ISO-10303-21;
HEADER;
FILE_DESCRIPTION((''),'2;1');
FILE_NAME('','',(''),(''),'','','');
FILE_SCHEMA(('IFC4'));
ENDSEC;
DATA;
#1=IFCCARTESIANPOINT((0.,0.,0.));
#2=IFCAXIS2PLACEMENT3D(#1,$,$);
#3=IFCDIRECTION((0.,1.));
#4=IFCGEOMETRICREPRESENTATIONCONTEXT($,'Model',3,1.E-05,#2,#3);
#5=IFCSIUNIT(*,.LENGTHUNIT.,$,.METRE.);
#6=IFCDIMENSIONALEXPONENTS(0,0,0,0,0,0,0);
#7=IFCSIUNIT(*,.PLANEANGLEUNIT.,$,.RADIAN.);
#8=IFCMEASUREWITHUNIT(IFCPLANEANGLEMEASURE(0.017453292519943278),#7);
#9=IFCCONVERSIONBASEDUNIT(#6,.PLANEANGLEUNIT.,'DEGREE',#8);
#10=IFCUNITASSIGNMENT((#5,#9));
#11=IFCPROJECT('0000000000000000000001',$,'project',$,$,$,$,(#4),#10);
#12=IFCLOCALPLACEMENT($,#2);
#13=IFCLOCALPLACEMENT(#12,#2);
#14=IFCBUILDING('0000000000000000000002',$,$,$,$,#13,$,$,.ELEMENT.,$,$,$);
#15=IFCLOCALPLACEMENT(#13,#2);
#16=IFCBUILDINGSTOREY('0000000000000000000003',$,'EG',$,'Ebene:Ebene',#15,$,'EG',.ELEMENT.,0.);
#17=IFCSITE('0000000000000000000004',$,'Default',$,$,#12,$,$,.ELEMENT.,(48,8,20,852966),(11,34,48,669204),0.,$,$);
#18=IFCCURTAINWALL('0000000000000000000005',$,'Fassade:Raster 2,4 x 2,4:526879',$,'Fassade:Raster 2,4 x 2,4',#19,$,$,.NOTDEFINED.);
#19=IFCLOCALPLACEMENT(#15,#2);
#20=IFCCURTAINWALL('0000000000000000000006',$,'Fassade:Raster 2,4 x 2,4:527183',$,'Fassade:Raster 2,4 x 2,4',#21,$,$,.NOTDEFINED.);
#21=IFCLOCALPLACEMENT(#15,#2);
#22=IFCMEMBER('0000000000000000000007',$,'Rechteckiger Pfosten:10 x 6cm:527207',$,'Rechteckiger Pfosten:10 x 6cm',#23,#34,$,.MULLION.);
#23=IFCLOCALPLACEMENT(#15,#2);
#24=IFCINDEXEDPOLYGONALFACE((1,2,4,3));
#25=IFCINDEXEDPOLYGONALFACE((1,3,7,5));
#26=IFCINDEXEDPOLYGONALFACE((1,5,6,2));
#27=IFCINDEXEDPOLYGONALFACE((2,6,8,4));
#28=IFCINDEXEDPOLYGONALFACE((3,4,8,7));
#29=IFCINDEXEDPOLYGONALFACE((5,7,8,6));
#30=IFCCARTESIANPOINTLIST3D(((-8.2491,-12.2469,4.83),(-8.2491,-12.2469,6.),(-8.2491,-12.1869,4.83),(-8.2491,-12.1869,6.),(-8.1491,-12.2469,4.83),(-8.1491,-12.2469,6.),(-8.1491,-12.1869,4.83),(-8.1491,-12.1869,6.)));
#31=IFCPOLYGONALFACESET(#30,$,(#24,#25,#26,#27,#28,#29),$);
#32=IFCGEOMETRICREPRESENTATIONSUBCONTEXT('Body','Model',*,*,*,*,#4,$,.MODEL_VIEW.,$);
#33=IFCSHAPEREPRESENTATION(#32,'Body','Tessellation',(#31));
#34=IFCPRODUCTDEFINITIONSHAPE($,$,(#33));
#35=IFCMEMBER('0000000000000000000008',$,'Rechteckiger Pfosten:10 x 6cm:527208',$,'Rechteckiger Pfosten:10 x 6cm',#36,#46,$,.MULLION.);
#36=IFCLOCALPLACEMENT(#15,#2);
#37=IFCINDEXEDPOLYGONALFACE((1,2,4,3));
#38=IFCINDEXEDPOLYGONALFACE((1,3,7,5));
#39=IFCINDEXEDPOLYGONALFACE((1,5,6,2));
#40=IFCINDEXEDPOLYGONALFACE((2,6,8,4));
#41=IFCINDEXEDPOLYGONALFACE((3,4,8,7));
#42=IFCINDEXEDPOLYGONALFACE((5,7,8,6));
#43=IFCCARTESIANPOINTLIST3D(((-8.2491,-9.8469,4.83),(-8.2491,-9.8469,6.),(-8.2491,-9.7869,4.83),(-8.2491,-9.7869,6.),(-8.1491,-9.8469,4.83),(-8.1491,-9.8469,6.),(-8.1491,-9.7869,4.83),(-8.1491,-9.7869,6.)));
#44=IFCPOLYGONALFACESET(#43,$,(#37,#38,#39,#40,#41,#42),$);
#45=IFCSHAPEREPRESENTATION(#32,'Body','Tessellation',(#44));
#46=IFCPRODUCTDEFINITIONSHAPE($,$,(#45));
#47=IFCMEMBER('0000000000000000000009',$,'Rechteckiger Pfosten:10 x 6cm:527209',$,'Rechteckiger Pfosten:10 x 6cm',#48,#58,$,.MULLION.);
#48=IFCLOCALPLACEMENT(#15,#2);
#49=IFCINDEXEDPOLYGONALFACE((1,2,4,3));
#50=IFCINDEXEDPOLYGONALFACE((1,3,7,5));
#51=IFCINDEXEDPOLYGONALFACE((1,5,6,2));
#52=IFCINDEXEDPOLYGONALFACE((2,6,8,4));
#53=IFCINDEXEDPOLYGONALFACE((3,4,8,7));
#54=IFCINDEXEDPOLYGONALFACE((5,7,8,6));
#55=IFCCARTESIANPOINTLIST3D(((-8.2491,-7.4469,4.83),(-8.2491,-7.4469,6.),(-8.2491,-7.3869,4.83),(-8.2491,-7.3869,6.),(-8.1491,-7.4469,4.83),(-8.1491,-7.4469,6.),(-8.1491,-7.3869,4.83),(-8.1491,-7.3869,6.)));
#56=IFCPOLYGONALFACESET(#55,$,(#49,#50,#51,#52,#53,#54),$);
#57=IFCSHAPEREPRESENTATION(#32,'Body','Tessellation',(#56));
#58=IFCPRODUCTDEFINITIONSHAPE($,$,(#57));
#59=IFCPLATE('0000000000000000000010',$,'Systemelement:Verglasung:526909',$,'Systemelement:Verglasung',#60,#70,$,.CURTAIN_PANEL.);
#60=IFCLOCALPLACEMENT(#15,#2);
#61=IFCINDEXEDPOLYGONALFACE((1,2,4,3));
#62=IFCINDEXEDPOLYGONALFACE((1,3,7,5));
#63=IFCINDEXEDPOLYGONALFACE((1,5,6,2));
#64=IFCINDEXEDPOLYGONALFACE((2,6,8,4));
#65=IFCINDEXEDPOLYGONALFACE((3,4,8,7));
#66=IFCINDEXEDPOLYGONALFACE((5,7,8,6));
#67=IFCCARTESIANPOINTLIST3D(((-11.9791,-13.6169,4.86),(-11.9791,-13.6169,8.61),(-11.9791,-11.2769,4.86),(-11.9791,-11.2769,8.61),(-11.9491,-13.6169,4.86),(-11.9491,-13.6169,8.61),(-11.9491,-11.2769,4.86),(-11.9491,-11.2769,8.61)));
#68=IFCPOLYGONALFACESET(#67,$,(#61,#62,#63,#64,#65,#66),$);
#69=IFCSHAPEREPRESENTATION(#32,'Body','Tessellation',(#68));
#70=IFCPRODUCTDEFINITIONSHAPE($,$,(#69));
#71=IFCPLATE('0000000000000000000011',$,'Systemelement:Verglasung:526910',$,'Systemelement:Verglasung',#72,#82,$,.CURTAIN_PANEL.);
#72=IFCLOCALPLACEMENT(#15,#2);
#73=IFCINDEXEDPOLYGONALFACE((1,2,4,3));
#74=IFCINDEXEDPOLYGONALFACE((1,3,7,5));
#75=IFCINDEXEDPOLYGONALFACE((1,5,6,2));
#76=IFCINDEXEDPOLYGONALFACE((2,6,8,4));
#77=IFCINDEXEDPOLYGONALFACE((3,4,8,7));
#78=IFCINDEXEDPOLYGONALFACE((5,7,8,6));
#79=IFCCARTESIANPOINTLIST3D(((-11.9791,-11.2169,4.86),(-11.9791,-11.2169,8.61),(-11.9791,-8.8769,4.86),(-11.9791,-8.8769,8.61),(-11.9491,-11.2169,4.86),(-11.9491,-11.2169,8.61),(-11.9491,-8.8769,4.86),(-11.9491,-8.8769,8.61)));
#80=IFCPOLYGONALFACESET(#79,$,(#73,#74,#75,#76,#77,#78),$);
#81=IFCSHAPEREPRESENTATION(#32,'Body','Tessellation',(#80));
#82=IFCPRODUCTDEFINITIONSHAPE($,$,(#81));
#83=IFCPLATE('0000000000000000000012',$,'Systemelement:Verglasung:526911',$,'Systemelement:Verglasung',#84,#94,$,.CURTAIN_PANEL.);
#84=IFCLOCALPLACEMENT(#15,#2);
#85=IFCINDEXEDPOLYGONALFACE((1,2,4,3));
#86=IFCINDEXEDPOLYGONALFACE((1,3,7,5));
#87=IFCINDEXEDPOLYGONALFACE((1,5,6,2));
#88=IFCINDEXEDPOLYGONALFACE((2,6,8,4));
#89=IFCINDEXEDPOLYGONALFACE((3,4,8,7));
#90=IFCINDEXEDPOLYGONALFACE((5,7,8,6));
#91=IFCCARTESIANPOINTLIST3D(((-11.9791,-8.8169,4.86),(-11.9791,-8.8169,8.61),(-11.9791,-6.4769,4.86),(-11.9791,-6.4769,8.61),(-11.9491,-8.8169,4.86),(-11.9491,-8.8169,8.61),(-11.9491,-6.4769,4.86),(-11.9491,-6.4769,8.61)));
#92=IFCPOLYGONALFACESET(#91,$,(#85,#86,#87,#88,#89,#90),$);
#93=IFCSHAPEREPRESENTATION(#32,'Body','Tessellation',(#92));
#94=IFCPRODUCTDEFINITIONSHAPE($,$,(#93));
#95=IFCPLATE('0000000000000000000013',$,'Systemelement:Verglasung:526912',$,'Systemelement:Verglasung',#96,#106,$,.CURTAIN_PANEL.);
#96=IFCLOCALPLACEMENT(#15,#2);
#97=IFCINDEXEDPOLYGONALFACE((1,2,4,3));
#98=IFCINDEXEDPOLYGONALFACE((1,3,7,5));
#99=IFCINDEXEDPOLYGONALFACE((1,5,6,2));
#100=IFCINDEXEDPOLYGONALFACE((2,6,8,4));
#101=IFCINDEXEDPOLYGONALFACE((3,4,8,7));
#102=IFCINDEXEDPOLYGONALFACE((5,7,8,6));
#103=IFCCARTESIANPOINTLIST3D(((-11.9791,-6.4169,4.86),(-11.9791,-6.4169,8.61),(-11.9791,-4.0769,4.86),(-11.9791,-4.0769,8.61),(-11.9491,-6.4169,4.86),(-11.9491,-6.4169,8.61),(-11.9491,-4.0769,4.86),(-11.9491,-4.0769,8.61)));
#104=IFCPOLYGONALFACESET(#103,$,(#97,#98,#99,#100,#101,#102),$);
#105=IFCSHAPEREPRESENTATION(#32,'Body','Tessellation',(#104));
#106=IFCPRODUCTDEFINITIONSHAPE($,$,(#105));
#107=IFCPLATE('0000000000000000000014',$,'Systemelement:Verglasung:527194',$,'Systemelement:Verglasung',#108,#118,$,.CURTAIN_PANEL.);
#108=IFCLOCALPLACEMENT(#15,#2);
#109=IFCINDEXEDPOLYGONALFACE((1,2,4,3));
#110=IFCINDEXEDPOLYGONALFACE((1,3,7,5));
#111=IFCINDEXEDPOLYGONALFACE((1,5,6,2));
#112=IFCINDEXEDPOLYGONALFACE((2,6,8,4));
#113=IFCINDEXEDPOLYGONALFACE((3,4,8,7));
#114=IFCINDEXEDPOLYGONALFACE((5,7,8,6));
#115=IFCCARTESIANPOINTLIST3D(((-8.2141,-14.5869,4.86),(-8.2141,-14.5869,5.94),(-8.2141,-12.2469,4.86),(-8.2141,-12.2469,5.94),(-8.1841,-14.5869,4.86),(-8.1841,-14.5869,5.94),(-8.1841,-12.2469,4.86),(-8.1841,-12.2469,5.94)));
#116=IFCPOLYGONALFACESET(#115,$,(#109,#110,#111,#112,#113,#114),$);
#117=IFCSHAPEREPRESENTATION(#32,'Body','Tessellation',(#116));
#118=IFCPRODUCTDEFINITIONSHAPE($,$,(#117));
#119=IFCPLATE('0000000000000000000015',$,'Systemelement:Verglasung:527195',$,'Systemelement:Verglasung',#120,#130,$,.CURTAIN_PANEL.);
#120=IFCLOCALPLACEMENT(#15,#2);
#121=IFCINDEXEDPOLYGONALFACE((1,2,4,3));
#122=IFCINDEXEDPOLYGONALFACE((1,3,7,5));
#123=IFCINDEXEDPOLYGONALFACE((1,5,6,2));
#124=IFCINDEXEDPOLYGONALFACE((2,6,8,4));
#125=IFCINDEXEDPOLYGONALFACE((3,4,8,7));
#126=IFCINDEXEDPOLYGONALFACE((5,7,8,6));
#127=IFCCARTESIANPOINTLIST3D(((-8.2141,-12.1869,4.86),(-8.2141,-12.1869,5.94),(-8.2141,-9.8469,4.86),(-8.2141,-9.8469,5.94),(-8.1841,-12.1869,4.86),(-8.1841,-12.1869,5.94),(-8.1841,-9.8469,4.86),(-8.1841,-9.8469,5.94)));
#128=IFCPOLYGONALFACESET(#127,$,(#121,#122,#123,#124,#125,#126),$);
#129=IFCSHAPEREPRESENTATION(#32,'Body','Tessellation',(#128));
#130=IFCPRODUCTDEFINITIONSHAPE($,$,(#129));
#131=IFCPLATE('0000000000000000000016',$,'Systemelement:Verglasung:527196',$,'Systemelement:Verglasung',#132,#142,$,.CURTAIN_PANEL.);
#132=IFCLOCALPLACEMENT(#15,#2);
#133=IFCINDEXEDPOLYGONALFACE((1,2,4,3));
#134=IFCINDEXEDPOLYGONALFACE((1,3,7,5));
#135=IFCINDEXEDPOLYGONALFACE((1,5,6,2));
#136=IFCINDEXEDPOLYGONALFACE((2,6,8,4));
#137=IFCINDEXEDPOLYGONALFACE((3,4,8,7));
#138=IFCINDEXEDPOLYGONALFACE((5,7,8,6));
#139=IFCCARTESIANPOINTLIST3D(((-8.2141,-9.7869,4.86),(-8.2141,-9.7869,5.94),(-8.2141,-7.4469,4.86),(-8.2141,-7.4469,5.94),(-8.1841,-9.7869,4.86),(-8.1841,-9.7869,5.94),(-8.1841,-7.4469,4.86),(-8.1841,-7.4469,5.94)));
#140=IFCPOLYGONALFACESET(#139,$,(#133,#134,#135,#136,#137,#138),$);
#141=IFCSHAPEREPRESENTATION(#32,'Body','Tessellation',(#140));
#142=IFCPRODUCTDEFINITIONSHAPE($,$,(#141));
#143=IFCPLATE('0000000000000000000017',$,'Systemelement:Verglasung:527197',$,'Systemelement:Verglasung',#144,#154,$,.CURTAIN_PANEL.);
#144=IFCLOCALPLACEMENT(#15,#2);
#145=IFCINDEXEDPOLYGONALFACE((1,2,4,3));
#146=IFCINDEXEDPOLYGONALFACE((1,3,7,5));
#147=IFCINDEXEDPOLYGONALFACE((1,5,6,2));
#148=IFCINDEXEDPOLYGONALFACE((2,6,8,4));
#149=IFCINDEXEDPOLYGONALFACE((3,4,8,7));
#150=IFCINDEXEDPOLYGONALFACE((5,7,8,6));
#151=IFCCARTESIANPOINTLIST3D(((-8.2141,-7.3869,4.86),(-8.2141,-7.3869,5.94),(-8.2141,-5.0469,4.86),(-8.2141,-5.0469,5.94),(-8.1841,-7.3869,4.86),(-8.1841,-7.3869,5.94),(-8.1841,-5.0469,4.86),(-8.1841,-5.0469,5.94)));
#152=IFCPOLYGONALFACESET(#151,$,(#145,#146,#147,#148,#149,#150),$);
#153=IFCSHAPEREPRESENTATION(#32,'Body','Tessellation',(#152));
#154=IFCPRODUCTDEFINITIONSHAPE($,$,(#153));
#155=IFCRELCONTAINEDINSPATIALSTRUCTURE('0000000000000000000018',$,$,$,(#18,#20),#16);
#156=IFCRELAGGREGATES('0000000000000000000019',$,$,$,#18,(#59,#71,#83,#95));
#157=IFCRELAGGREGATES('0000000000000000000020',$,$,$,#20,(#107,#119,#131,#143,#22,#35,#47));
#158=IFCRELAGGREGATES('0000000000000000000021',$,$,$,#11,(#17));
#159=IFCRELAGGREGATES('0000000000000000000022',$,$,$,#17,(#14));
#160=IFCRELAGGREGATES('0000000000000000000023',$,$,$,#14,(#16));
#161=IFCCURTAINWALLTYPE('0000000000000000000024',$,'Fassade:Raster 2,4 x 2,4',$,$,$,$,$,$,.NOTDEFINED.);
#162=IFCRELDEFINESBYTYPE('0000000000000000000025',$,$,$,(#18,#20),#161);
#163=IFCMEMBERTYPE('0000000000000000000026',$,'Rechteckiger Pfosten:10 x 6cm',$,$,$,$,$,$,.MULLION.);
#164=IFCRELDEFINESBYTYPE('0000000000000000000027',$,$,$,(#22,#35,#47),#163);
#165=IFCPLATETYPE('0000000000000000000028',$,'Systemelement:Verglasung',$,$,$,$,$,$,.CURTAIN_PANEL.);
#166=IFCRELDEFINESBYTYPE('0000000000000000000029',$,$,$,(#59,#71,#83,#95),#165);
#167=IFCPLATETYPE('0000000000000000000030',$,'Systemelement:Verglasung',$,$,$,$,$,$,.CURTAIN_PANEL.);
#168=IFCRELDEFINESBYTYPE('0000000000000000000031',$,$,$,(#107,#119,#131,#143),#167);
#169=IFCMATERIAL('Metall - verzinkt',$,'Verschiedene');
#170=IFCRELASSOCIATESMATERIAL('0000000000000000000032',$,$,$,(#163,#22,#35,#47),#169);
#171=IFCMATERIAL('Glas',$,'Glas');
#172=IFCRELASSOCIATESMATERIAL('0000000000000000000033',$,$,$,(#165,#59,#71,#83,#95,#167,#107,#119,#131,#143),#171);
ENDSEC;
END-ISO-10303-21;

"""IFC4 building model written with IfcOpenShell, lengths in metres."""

from ifc_helpers import new_model, entity, si_unit, converted_unit, direction, frame, origin, place, context, subcontext, project, spatial, indexed_curve, outline, extrude, source, transform, mapped, material, type_object, type_shapes, element, aggregate, save


model = new_model("IFC4")

# Units and contexts
model_context = context("Model", 3, precision=1e-05, world=origin(), true_north=direction((0.0, 1.0)))
body_context = subcontext(model_context, "Body", "Model", "MODEL_VIEW")
ifc_project = project(units=[si_unit("LENGTHUNIT", "METRE"), converted_unit("PLANEANGLEUNIT", "DEGREE", entity("IfcPlaneAngleMeasure", 0.017453292519943278), si_unit("PLANEANGLEUNIT", "RADIAN"), dimensions=[0, 0, 0, 0, 0, 0, 0])], contexts=[model_context])

# Site, building, storey
site_placement = place(None, origin())
site = spatial("IfcSite", under=ifc_project, at=site_placement, Name="Default", CompositionType="ELEMENT", RefLatitude=(48, 8, 20, 852966), RefLongitude=(11, 34, 48, 669204), RefElevation=0.0)
building_placement = place(site_placement, origin())
building = spatial("IfcBuilding", under=site, at=building_placement, CompositionType="ELEMENT")
storey_placement = place(building_placement, origin())
storey = spatial("IfcBuildingStorey", under=building, at=storey_placement, Name="EG", ObjectType="Ebene:Ebene", LongName="EG", CompositionType="ELEMENT", Elevation=0.0)

# Curtain walls
curtain_wall_type = type_object("IfcCurtainWallType", Name="Fassade:Raster 2,4 x 2,4", PredefinedType="NOTDEFINED")
curtain_wall_1_placement = place(storey_placement, origin())
curtain_wall_1 = element("IfcCurtainWall", 1, at=curtain_wall_1_placement, inside=storey, type_object=curtain_wall_type, Name="Fassade:Raster 2,4 x 2,4:526879", ObjectType="Fassade:Raster 2,4 x 2,4", PredefinedType="NOTDEFINED")
ifc_material_1 = material(Name="Metall - verzinkt", Category="Verschiedene")
curtain_wall_2_placement = place(storey_placement, origin())
curtain_wall_2 = element("IfcCurtainWall", 2, at=curtain_wall_2_placement, inside=storey, type_object=curtain_wall_type, Name="Fassade:Raster 2,4 x 2,4:527183", ObjectType="Fassade:Raster 2,4 x 2,4", PredefinedType="NOTDEFINED")

# Members
member_type_1 = type_object("IfcMemberType", Name="Rechteckiger Pfosten:10 x 6cm", PredefinedType="MULLION", material=ifc_material_1)
shared_shape_1 = source(origin(), body_context, "Body", "SweptSolid", [
    extrude(outline(indexed_curve([(-0.03, -0.05), (0.03, -0.05), (0.03, 0.05), (-0.03, 0.05), (-0.03, -0.05)], self_intersect=False)), frame((0.0, 0.0, -1.17), z_axis=(0.0, 0.0, 1.0), x_axis=(-1.0, 0.0, 0.0)), (0.0, 0.0, 1.0), 1.17),
])
type_shapes(member_type_1, [shared_shape_1])
member_1_placement = place(curtain_wall_2_placement, frame((-8.1991, -12.2169, 4.83), z_axis=(0.0, 0.0, -1.0), x_axis=(0.0, 1.0, 0.0)))
member_1 = element("IfcMember", 3, at=member_1_placement, type_object=member_type_1, material=ifc_material_1, Name="Rechteckiger Pfosten:10 x 6cm:527207", ObjectType="Rechteckiger Pfosten:10 x 6cm", PredefinedType="MULLION", context=body_context, shape_type="MappedRepresentation", body=[
    mapped(shared_shape_1, transform((0.0, 0.0, 0.0), scale=1.0)),
])
member_2_placement = place(curtain_wall_2_placement, frame((-8.1991, -9.8169, 4.83), z_axis=(0.0, 0.0, -1.0), x_axis=(0.0, 1.0, 0.0)))
member_2 = element("IfcMember", 4, at=member_2_placement, type_object=member_type_1, material=ifc_material_1, Name="Rechteckiger Pfosten:10 x 6cm:527208", ObjectType="Rechteckiger Pfosten:10 x 6cm", PredefinedType="MULLION", context=body_context, shape_type="MappedRepresentation", body=[
    mapped(shared_shape_1, transform((0.0, 0.0, 0.0), scale=1.0)),
])
member_3_placement = place(curtain_wall_2_placement, frame((-8.1991, -7.4169, 4.83), z_axis=(0.0, 0.0, -1.0), x_axis=(0.0, 1.0, 0.0)))
member_3 = element("IfcMember", 5, at=member_3_placement, type_object=member_type_1, material=ifc_material_1, Name="Rechteckiger Pfosten:10 x 6cm:527209", ObjectType="Rechteckiger Pfosten:10 x 6cm", PredefinedType="MULLION", context=body_context, shape_type="MappedRepresentation", body=[
    mapped(shared_shape_1, transform((0.0, 0.0, 0.0), scale=1.0)),
])

# Plates
ifc_material_2 = material(Name="Glas", Category="Glas")
plate_type_1 = type_object("IfcPlateType", Name="Systemelement:Verglasung", PredefinedType="CURTAIN_PANEL", material=ifc_material_2)
shared_shape_2 = source(origin(), body_context, "Body", "SweptSolid", [
    extrude(outline(indexed_curve([(-0.015, -1.17), (0.015, -1.17), (0.015, 1.17), (-0.015, 1.17), (-0.015, -1.17)], self_intersect=False)), frame((0.0, 0.0, 0.0), z_axis=(0.0, 0.0, 1.0), x_axis=(0.0, 1.0, 0.0)), (0.0, 0.0, 1.0), 3.75),
])
type_shapes(plate_type_1, [shared_shape_2])
plate_1_placement = place(curtain_wall_1_placement, frame((-11.9641, -12.4469, 4.86), z_axis=(0.0, 0.0, 1.0), x_axis=(0.0, 1.0, 0.0)))
plate_1 = element("IfcPlate", 6, at=plate_1_placement, type_object=plate_type_1, material=ifc_material_2, Name="Systemelement:Verglasung:526909", ObjectType="Systemelement:Verglasung", PredefinedType="CURTAIN_PANEL", context=body_context, shape_type="MappedRepresentation", body=[
    mapped(shared_shape_2, transform((0.0, 0.0, 0.0), scale=1.0)),
])
plate_2_placement = place(curtain_wall_1_placement, frame((-11.9641, -10.0469, 4.86), z_axis=(0.0, 0.0, 1.0), x_axis=(0.0, 1.0, 0.0)))
plate_2 = element("IfcPlate", 7, at=plate_2_placement, type_object=plate_type_1, material=ifc_material_2, Name="Systemelement:Verglasung:526910", ObjectType="Systemelement:Verglasung", PredefinedType="CURTAIN_PANEL", context=body_context, shape_type="MappedRepresentation", body=[
    mapped(shared_shape_2, transform((0.0, 0.0, 0.0), scale=1.0)),
])
plate_3_placement = place(curtain_wall_1_placement, frame((-11.9641, -7.6469, 4.86), z_axis=(0.0, 0.0, 1.0), x_axis=(0.0, 1.0, 0.0)))
plate_3 = element("IfcPlate", 8, at=plate_3_placement, type_object=plate_type_1, material=ifc_material_2, Name="Systemelement:Verglasung:526911", ObjectType="Systemelement:Verglasung", PredefinedType="CURTAIN_PANEL", context=body_context, shape_type="MappedRepresentation", body=[
    mapped(shared_shape_2, transform((0.0, 0.0, 0.0), scale=1.0)),
])
plate_4_placement = place(curtain_wall_1_placement, frame((-11.9641, -5.2469, 4.86), z_axis=(0.0, 0.0, 1.0), x_axis=(0.0, 1.0, 0.0)))
plate_4 = element("IfcPlate", 9, at=plate_4_placement, type_object=plate_type_1, material=ifc_material_2, Name="Systemelement:Verglasung:526912", ObjectType="Systemelement:Verglasung", PredefinedType="CURTAIN_PANEL", context=body_context, shape_type="MappedRepresentation", body=[
    mapped(shared_shape_2, transform((0.0, 0.0, 0.0), scale=1.0)),
])
aggregate(curtain_wall_1, [plate_1, plate_2, plate_3, plate_4])
plate_type_2 = type_object("IfcPlateType", Name="Systemelement:Verglasung", PredefinedType="CURTAIN_PANEL", material=ifc_material_2)
shared_shape_3 = source(origin(), body_context, "Body", "SweptSolid", [
    extrude(outline(indexed_curve([(-0.015, -1.17), (0.015, -1.17), (0.015, 1.17), (-0.015, 1.17), (-0.015, -1.17)], self_intersect=False)), frame((0.0, 0.0, 0.0), z_axis=(0.0, 0.0, 1.0), x_axis=(0.0, 1.0, 0.0)), (0.0, 0.0, 1.0), 1.08),
])
type_shapes(plate_type_2, [shared_shape_3])
plate_5_placement = place(curtain_wall_2_placement, frame((-8.1991, -13.4169, 4.86), z_axis=(0.0, 0.0, 1.0), x_axis=(0.0, 1.0, 0.0)))
plate_5 = element("IfcPlate", 10, at=plate_5_placement, type_object=plate_type_2, material=ifc_material_2, Name="Systemelement:Verglasung:527194", ObjectType="Systemelement:Verglasung", PredefinedType="CURTAIN_PANEL", context=body_context, shape_type="MappedRepresentation", body=[
    mapped(shared_shape_3, transform((0.0, 0.0, 0.0), scale=1.0)),
])
plate_6_placement = place(curtain_wall_2_placement, frame((-8.1991, -11.0169, 4.86), z_axis=(0.0, 0.0, 1.0), x_axis=(0.0, 1.0, 0.0)))
plate_6 = element("IfcPlate", 11, at=plate_6_placement, type_object=plate_type_2, material=ifc_material_2, Name="Systemelement:Verglasung:527195", ObjectType="Systemelement:Verglasung", PredefinedType="CURTAIN_PANEL", context=body_context, shape_type="MappedRepresentation", body=[
    mapped(shared_shape_3, transform((0.0, 0.0, 0.0), scale=1.0)),
])
plate_7_placement = place(curtain_wall_2_placement, frame((-8.1991, -8.6169, 4.86), z_axis=(0.0, 0.0, 1.0), x_axis=(0.0, 1.0, 0.0)))
plate_7 = element("IfcPlate", 12, at=plate_7_placement, type_object=plate_type_2, material=ifc_material_2, Name="Systemelement:Verglasung:527196", ObjectType="Systemelement:Verglasung", PredefinedType="CURTAIN_PANEL", context=body_context, shape_type="MappedRepresentation", body=[
    mapped(shared_shape_3, transform((0.0, 0.0, 0.0), scale=1.0)),
])
plate_8_placement = place(curtain_wall_2_placement, frame((-8.1991, -6.2169, 4.86), z_axis=(0.0, 0.0, 1.0), x_axis=(0.0, 1.0, 0.0)))
plate_8 = element("IfcPlate", 13, at=plate_8_placement, type_object=plate_type_2, material=ifc_material_2, Name="Systemelement:Verglasung:527197", ObjectType="Systemelement:Verglasung", PredefinedType="CURTAIN_PANEL", context=body_context, shape_type="MappedRepresentation", body=[
    mapped(shared_shape_3, transform((0.0, 0.0, 0.0), scale=1.0)),
])
aggregate(curtain_wall_2, [plate_5, plate_6, plate_7, plate_8, member_1, member_2, member_3])

save(model, "model.ifc")
